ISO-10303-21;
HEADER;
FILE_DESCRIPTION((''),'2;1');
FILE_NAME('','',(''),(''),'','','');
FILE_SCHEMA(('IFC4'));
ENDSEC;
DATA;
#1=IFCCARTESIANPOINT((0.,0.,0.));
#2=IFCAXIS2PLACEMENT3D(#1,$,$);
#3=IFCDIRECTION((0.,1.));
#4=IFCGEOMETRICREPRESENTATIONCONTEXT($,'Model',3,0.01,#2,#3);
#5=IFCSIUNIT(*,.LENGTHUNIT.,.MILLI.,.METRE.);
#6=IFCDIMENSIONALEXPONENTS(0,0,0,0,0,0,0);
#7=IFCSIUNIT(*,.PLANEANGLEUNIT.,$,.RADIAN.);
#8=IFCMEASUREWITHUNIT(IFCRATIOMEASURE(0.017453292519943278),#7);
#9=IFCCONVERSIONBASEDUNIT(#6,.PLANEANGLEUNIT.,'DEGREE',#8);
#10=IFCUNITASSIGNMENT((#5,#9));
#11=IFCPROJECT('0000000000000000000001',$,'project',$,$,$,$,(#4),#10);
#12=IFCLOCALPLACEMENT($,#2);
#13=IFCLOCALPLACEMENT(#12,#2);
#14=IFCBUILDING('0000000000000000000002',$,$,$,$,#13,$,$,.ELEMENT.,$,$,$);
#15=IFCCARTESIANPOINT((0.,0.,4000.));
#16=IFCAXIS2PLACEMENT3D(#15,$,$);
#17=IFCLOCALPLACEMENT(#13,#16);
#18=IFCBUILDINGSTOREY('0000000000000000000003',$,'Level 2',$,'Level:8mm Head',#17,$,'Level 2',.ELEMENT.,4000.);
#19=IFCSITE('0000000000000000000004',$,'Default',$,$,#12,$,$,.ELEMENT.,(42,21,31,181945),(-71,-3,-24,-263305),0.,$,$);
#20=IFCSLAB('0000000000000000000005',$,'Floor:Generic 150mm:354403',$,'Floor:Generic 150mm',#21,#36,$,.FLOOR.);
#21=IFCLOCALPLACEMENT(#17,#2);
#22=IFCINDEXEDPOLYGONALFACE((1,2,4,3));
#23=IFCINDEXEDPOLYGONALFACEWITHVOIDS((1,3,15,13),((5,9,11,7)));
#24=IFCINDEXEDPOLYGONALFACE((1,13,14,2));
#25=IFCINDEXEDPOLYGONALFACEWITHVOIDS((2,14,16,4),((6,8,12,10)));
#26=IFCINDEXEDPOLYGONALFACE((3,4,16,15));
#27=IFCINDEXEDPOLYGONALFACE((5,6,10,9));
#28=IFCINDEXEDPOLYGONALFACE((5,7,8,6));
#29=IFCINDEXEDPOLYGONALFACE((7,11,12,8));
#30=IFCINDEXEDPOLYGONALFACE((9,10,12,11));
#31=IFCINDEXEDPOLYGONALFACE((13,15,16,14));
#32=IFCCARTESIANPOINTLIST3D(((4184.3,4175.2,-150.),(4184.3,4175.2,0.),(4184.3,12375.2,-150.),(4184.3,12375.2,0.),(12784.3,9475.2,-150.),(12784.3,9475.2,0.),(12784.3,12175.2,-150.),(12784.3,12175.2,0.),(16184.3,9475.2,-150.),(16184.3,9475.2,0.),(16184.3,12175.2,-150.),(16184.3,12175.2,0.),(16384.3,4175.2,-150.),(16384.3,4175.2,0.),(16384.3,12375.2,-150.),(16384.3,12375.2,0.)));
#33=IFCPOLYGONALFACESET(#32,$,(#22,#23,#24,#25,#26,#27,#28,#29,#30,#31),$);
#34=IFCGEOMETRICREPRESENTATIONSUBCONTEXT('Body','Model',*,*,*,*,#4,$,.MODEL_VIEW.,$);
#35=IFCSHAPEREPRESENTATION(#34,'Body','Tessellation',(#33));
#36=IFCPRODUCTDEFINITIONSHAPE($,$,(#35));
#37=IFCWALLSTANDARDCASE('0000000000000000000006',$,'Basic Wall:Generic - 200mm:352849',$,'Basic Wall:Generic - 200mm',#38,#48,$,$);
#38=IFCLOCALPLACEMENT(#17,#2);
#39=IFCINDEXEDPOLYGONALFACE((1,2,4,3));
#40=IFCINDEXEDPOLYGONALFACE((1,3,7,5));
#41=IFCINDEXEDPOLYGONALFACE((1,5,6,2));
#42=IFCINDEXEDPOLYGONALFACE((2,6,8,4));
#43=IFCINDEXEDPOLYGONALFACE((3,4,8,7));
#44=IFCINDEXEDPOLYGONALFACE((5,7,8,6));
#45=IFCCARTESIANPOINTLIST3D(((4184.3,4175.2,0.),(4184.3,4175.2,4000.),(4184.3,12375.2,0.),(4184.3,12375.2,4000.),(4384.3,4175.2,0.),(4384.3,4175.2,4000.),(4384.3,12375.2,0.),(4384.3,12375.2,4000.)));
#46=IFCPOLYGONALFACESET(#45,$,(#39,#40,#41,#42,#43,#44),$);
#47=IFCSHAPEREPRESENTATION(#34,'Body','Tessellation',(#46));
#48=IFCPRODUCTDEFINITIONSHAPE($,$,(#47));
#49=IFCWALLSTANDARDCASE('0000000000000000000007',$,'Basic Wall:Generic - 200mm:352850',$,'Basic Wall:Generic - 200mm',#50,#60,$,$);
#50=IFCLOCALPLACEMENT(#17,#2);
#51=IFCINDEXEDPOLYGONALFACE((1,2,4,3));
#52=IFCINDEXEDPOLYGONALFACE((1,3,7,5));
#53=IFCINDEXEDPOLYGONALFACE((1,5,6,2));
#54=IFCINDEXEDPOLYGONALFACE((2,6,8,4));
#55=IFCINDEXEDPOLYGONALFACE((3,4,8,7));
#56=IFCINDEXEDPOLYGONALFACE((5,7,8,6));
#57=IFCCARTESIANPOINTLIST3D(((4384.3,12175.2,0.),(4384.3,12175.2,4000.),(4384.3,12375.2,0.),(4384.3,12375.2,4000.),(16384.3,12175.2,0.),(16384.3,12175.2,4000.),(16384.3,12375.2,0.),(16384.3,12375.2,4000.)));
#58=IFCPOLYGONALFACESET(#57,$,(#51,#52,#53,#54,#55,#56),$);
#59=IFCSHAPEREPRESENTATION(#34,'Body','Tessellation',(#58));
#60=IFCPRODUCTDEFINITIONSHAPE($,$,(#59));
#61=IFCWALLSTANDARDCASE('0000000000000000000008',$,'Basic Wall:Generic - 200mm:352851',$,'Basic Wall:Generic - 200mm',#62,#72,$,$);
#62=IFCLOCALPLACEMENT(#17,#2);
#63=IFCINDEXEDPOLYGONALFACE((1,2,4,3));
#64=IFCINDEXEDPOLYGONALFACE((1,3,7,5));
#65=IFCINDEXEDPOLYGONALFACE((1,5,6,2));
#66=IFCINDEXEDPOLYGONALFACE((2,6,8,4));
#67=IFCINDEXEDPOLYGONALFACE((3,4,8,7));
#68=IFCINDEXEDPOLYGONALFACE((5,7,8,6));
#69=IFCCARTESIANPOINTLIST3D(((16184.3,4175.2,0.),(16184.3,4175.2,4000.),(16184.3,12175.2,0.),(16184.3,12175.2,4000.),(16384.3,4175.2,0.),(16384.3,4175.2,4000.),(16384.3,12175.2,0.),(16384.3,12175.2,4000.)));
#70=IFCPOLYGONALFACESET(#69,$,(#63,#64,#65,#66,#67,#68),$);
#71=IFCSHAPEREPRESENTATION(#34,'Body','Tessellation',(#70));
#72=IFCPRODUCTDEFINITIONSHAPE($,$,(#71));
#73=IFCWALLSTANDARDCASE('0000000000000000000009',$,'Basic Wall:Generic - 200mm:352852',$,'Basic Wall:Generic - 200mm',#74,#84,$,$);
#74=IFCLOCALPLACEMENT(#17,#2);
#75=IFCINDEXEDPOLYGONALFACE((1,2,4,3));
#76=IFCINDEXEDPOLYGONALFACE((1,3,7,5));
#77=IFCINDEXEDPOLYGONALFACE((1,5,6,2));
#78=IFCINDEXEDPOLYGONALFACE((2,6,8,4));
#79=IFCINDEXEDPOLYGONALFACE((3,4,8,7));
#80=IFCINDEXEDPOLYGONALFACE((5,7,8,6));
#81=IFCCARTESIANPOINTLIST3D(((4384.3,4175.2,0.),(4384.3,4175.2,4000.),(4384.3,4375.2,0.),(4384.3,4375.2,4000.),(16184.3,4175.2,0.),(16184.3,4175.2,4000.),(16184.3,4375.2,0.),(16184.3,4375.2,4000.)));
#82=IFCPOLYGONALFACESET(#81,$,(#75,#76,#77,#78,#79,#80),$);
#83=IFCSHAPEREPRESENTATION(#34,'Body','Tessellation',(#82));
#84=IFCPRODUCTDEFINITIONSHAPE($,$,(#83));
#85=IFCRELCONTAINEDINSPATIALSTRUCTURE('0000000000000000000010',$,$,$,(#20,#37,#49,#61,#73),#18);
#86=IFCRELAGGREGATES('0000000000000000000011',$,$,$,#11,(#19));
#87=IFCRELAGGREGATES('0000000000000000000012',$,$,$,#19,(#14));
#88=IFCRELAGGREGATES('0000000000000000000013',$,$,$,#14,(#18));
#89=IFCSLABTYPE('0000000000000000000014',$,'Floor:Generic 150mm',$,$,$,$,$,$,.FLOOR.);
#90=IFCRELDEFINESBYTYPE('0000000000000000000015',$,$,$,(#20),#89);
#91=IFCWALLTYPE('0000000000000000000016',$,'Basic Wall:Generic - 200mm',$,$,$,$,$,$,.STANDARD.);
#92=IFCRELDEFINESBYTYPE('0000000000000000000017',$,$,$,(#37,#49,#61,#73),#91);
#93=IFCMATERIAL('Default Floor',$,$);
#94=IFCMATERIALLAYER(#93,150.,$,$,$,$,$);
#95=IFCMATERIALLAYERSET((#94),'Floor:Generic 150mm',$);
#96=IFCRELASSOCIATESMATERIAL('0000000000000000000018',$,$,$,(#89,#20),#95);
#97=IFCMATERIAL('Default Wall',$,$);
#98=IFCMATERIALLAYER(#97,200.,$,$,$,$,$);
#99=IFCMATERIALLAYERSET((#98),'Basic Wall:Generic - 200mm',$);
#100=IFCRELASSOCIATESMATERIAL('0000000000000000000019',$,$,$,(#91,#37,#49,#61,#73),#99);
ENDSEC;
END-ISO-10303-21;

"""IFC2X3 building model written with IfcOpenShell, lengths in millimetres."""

from ifc_helpers import new_model, entity, si_unit, converted_unit, direction, frame, frame_2d, origin, place, context, subcontext, project, spatial, rectangle, extrude, material, layer, layer_set, layer_usage, type_object, element, save


model = new_model("IFC2X3")

# Units and contexts
model_context = context("Model", 3, precision=0.01, world=origin(), true_north=direction((0.0, 1.0)))
body_context = subcontext(model_context, "Body", "Model", "MODEL_VIEW")
ifc_project = project(units=[si_unit("LENGTHUNIT", "METRE", prefix="MILLI"), converted_unit("PLANEANGLEUNIT", "DEGREE", entity("IfcRatioMeasure", 0.017453292519943278), si_unit("PLANEANGLEUNIT", "RADIAN"), dimensions=[0, 0, 0, 0, 0, 0, 0])], contexts=[model_context])

# Site, building, storey
site_placement = place(None, origin())
site = spatial("IfcSite", under=ifc_project, at=site_placement, Name="Default", CompositionType="ELEMENT", RefLatitude=(42, 21, 31, 181945), RefLongitude=(-71, -3, -24, -263305), RefElevation=0.0)
building_placement = place(site_placement, origin())
building = spatial("IfcBuilding", under=site, at=building_placement, CompositionType="ELEMENT")
storey_placement = place(building_placement, frame((0.0, 0.0, 4000.0)))
storey = spatial("IfcBuildingStorey", under=building, at=storey_placement, Name="Level 2", ObjectType="Level:8mm Head", LongName="Level 2", CompositionType="ELEMENT", Elevation=4000.0)

# Slab, opening
ifc_material_1 = material(Name="Default Floor")
ifc_layer_1 = layer(ifc_material_1, 150.0)
ifc_layer_set_1 = layer_set([ifc_layer_1], Name="Floor:Generic 150mm")
ifc_layer_usage_1 = layer_usage(ifc_layer_set_1, "AXIS3", "POSITIVE", 0.0)
slab_type = type_object("IfcSlabType", Name="Floor:Generic 150mm", PredefinedType="FLOOR", material=ifc_layer_set_1)
slab_placement = place(storey_placement, frame((4184.3, 4175.2, -150.0)))
slab = element("IfcSlab", 1, at=slab_placement, inside=storey, type_object=slab_type, material=ifc_layer_usage_1, Name="Floor:Generic 150mm:354403", ObjectType="Floor:Generic 150mm", PredefinedType="FLOOR", context=body_context, shape_type="SweptSolid", body=[
    extrude(rectangle(XDim=12200.0, YDim=8200.0, at=frame_2d((0.0, 0.0), x_axis=(-1.0, 0.0))), frame((6100.0, 4100.0, 150.0), z_axis=(0.0, 0.0, -1.0), x_axis=(-1.0, 0.0, 0.0)), (0.0, 0.0, 1.0), 150.0),
])
opening_placement = place(slab_placement, origin())
element("IfcOpeningElement", 2, at=opening_placement, cuts=slab, ObjectType="Opening", context=body_context, shape_type="SweptSolid", body=[
    extrude(rectangle(XDim=3400.0, YDim=2700.0, at=frame_2d((0.0, 0.0), x_axis=(1.0, 0.0))), frame((10300.0, 6650.0, 150.0), z_axis=(0.0, 0.0, -1.0), x_axis=(-1.0, 0.0, 0.0)), (0.0, 0.0, 1.0), 150.0),
])

# Walls
ifc_material_2 = material(Name="Default Wall")
ifc_layer_2 = layer(ifc_material_2, 200.0)
ifc_layer_set_2 = layer_set([ifc_layer_2], Name="Basic Wall:Generic - 200mm")
ifc_layer_usage_2 = layer_usage(ifc_layer_set_2, "AXIS2", "NEGATIVE", 100.0)
wall_type = type_object("IfcWallType", Name="Basic Wall:Generic - 200mm", PredefinedType="STANDARD", material=ifc_layer_set_2)
wall_1_placement = place(storey_placement, frame((4284.3, 4175.2, 0.0), z_axis=(0.0, 0.0, 1.0), x_axis=(0.0, 1.0, 0.0)))
element("IfcWallStandardCase", 3, at=wall_1_placement, inside=storey, type_object=wall_type, material=ifc_layer_usage_2, Name="Basic Wall:Generic - 200mm:352849", ObjectType="Basic Wall:Generic - 200mm", context=body_context, shape_type="SweptSolid", body=[
    extrude(rectangle(XDim=8200.0, YDim=200.0, at=frame_2d((4100.0, 0.0), x_axis=(-1.0, 0.0))), origin(), (0.0, 0.0, 1.0), 4000.0),
])
wall_2_placement = place(storey_placement, frame((4384.3, 12275.2, 0.0)))
element("IfcWallStandardCase", 4, at=wall_2_placement, inside=storey, type_object=wall_type, material=ifc_layer_usage_2, Name="Basic Wall:Generic - 200mm:352850", ObjectType="Basic Wall:Generic - 200mm", context=body_context, shape_type="SweptSolid", body=[
    extrude(rectangle(XDim=12000.0, YDim=200.0, at=frame_2d((6000.0, 0.0), x_axis=(-1.0, 0.0))), origin(), (0.0, 0.0, 1.0), 4000.0),
])
wall_3_placement = place(storey_placement, frame((16284.3, 12175.2, 0.0), z_axis=(0.0, 0.0, 1.0), x_axis=(0.0, -1.0, 0.0)))
element("IfcWallStandardCase", 5, at=wall_3_placement, inside=storey, type_object=wall_type, material=ifc_layer_usage_2, Name="Basic Wall:Generic - 200mm:352851", ObjectType="Basic Wall:Generic - 200mm", context=body_context, shape_type="SweptSolid", body=[
    extrude(rectangle(XDim=8000.0, YDim=200.0, at=frame_2d((4000.0, 0.0), x_axis=(-1.0, 0.0))), origin(), (0.0, 0.0, 1.0), 4000.0),
])
wall_4_placement = place(storey_placement, frame((16184.3, 4275.2, 0.0), z_axis=(0.0, 0.0, 1.0), x_axis=(-1.0, 0.0, 0.0)))
element("IfcWallStandardCase", 6, at=wall_4_placement, inside=storey, type_object=wall_type, material=ifc_layer_usage_2, Name="Basic Wall:Generic - 200mm:352852", ObjectType="Basic Wall:Generic - 200mm", context=body_context, shape_type="SweptSolid", body=[
    extrude(rectangle(XDim=11800.0, YDim=200.0, at=frame_2d((5900.0, 0.0), x_axis=(-1.0, 0.0))), origin(), (0.0, 0.0, 1.0), 4000.0),
])

save(model, "model.ifc")
